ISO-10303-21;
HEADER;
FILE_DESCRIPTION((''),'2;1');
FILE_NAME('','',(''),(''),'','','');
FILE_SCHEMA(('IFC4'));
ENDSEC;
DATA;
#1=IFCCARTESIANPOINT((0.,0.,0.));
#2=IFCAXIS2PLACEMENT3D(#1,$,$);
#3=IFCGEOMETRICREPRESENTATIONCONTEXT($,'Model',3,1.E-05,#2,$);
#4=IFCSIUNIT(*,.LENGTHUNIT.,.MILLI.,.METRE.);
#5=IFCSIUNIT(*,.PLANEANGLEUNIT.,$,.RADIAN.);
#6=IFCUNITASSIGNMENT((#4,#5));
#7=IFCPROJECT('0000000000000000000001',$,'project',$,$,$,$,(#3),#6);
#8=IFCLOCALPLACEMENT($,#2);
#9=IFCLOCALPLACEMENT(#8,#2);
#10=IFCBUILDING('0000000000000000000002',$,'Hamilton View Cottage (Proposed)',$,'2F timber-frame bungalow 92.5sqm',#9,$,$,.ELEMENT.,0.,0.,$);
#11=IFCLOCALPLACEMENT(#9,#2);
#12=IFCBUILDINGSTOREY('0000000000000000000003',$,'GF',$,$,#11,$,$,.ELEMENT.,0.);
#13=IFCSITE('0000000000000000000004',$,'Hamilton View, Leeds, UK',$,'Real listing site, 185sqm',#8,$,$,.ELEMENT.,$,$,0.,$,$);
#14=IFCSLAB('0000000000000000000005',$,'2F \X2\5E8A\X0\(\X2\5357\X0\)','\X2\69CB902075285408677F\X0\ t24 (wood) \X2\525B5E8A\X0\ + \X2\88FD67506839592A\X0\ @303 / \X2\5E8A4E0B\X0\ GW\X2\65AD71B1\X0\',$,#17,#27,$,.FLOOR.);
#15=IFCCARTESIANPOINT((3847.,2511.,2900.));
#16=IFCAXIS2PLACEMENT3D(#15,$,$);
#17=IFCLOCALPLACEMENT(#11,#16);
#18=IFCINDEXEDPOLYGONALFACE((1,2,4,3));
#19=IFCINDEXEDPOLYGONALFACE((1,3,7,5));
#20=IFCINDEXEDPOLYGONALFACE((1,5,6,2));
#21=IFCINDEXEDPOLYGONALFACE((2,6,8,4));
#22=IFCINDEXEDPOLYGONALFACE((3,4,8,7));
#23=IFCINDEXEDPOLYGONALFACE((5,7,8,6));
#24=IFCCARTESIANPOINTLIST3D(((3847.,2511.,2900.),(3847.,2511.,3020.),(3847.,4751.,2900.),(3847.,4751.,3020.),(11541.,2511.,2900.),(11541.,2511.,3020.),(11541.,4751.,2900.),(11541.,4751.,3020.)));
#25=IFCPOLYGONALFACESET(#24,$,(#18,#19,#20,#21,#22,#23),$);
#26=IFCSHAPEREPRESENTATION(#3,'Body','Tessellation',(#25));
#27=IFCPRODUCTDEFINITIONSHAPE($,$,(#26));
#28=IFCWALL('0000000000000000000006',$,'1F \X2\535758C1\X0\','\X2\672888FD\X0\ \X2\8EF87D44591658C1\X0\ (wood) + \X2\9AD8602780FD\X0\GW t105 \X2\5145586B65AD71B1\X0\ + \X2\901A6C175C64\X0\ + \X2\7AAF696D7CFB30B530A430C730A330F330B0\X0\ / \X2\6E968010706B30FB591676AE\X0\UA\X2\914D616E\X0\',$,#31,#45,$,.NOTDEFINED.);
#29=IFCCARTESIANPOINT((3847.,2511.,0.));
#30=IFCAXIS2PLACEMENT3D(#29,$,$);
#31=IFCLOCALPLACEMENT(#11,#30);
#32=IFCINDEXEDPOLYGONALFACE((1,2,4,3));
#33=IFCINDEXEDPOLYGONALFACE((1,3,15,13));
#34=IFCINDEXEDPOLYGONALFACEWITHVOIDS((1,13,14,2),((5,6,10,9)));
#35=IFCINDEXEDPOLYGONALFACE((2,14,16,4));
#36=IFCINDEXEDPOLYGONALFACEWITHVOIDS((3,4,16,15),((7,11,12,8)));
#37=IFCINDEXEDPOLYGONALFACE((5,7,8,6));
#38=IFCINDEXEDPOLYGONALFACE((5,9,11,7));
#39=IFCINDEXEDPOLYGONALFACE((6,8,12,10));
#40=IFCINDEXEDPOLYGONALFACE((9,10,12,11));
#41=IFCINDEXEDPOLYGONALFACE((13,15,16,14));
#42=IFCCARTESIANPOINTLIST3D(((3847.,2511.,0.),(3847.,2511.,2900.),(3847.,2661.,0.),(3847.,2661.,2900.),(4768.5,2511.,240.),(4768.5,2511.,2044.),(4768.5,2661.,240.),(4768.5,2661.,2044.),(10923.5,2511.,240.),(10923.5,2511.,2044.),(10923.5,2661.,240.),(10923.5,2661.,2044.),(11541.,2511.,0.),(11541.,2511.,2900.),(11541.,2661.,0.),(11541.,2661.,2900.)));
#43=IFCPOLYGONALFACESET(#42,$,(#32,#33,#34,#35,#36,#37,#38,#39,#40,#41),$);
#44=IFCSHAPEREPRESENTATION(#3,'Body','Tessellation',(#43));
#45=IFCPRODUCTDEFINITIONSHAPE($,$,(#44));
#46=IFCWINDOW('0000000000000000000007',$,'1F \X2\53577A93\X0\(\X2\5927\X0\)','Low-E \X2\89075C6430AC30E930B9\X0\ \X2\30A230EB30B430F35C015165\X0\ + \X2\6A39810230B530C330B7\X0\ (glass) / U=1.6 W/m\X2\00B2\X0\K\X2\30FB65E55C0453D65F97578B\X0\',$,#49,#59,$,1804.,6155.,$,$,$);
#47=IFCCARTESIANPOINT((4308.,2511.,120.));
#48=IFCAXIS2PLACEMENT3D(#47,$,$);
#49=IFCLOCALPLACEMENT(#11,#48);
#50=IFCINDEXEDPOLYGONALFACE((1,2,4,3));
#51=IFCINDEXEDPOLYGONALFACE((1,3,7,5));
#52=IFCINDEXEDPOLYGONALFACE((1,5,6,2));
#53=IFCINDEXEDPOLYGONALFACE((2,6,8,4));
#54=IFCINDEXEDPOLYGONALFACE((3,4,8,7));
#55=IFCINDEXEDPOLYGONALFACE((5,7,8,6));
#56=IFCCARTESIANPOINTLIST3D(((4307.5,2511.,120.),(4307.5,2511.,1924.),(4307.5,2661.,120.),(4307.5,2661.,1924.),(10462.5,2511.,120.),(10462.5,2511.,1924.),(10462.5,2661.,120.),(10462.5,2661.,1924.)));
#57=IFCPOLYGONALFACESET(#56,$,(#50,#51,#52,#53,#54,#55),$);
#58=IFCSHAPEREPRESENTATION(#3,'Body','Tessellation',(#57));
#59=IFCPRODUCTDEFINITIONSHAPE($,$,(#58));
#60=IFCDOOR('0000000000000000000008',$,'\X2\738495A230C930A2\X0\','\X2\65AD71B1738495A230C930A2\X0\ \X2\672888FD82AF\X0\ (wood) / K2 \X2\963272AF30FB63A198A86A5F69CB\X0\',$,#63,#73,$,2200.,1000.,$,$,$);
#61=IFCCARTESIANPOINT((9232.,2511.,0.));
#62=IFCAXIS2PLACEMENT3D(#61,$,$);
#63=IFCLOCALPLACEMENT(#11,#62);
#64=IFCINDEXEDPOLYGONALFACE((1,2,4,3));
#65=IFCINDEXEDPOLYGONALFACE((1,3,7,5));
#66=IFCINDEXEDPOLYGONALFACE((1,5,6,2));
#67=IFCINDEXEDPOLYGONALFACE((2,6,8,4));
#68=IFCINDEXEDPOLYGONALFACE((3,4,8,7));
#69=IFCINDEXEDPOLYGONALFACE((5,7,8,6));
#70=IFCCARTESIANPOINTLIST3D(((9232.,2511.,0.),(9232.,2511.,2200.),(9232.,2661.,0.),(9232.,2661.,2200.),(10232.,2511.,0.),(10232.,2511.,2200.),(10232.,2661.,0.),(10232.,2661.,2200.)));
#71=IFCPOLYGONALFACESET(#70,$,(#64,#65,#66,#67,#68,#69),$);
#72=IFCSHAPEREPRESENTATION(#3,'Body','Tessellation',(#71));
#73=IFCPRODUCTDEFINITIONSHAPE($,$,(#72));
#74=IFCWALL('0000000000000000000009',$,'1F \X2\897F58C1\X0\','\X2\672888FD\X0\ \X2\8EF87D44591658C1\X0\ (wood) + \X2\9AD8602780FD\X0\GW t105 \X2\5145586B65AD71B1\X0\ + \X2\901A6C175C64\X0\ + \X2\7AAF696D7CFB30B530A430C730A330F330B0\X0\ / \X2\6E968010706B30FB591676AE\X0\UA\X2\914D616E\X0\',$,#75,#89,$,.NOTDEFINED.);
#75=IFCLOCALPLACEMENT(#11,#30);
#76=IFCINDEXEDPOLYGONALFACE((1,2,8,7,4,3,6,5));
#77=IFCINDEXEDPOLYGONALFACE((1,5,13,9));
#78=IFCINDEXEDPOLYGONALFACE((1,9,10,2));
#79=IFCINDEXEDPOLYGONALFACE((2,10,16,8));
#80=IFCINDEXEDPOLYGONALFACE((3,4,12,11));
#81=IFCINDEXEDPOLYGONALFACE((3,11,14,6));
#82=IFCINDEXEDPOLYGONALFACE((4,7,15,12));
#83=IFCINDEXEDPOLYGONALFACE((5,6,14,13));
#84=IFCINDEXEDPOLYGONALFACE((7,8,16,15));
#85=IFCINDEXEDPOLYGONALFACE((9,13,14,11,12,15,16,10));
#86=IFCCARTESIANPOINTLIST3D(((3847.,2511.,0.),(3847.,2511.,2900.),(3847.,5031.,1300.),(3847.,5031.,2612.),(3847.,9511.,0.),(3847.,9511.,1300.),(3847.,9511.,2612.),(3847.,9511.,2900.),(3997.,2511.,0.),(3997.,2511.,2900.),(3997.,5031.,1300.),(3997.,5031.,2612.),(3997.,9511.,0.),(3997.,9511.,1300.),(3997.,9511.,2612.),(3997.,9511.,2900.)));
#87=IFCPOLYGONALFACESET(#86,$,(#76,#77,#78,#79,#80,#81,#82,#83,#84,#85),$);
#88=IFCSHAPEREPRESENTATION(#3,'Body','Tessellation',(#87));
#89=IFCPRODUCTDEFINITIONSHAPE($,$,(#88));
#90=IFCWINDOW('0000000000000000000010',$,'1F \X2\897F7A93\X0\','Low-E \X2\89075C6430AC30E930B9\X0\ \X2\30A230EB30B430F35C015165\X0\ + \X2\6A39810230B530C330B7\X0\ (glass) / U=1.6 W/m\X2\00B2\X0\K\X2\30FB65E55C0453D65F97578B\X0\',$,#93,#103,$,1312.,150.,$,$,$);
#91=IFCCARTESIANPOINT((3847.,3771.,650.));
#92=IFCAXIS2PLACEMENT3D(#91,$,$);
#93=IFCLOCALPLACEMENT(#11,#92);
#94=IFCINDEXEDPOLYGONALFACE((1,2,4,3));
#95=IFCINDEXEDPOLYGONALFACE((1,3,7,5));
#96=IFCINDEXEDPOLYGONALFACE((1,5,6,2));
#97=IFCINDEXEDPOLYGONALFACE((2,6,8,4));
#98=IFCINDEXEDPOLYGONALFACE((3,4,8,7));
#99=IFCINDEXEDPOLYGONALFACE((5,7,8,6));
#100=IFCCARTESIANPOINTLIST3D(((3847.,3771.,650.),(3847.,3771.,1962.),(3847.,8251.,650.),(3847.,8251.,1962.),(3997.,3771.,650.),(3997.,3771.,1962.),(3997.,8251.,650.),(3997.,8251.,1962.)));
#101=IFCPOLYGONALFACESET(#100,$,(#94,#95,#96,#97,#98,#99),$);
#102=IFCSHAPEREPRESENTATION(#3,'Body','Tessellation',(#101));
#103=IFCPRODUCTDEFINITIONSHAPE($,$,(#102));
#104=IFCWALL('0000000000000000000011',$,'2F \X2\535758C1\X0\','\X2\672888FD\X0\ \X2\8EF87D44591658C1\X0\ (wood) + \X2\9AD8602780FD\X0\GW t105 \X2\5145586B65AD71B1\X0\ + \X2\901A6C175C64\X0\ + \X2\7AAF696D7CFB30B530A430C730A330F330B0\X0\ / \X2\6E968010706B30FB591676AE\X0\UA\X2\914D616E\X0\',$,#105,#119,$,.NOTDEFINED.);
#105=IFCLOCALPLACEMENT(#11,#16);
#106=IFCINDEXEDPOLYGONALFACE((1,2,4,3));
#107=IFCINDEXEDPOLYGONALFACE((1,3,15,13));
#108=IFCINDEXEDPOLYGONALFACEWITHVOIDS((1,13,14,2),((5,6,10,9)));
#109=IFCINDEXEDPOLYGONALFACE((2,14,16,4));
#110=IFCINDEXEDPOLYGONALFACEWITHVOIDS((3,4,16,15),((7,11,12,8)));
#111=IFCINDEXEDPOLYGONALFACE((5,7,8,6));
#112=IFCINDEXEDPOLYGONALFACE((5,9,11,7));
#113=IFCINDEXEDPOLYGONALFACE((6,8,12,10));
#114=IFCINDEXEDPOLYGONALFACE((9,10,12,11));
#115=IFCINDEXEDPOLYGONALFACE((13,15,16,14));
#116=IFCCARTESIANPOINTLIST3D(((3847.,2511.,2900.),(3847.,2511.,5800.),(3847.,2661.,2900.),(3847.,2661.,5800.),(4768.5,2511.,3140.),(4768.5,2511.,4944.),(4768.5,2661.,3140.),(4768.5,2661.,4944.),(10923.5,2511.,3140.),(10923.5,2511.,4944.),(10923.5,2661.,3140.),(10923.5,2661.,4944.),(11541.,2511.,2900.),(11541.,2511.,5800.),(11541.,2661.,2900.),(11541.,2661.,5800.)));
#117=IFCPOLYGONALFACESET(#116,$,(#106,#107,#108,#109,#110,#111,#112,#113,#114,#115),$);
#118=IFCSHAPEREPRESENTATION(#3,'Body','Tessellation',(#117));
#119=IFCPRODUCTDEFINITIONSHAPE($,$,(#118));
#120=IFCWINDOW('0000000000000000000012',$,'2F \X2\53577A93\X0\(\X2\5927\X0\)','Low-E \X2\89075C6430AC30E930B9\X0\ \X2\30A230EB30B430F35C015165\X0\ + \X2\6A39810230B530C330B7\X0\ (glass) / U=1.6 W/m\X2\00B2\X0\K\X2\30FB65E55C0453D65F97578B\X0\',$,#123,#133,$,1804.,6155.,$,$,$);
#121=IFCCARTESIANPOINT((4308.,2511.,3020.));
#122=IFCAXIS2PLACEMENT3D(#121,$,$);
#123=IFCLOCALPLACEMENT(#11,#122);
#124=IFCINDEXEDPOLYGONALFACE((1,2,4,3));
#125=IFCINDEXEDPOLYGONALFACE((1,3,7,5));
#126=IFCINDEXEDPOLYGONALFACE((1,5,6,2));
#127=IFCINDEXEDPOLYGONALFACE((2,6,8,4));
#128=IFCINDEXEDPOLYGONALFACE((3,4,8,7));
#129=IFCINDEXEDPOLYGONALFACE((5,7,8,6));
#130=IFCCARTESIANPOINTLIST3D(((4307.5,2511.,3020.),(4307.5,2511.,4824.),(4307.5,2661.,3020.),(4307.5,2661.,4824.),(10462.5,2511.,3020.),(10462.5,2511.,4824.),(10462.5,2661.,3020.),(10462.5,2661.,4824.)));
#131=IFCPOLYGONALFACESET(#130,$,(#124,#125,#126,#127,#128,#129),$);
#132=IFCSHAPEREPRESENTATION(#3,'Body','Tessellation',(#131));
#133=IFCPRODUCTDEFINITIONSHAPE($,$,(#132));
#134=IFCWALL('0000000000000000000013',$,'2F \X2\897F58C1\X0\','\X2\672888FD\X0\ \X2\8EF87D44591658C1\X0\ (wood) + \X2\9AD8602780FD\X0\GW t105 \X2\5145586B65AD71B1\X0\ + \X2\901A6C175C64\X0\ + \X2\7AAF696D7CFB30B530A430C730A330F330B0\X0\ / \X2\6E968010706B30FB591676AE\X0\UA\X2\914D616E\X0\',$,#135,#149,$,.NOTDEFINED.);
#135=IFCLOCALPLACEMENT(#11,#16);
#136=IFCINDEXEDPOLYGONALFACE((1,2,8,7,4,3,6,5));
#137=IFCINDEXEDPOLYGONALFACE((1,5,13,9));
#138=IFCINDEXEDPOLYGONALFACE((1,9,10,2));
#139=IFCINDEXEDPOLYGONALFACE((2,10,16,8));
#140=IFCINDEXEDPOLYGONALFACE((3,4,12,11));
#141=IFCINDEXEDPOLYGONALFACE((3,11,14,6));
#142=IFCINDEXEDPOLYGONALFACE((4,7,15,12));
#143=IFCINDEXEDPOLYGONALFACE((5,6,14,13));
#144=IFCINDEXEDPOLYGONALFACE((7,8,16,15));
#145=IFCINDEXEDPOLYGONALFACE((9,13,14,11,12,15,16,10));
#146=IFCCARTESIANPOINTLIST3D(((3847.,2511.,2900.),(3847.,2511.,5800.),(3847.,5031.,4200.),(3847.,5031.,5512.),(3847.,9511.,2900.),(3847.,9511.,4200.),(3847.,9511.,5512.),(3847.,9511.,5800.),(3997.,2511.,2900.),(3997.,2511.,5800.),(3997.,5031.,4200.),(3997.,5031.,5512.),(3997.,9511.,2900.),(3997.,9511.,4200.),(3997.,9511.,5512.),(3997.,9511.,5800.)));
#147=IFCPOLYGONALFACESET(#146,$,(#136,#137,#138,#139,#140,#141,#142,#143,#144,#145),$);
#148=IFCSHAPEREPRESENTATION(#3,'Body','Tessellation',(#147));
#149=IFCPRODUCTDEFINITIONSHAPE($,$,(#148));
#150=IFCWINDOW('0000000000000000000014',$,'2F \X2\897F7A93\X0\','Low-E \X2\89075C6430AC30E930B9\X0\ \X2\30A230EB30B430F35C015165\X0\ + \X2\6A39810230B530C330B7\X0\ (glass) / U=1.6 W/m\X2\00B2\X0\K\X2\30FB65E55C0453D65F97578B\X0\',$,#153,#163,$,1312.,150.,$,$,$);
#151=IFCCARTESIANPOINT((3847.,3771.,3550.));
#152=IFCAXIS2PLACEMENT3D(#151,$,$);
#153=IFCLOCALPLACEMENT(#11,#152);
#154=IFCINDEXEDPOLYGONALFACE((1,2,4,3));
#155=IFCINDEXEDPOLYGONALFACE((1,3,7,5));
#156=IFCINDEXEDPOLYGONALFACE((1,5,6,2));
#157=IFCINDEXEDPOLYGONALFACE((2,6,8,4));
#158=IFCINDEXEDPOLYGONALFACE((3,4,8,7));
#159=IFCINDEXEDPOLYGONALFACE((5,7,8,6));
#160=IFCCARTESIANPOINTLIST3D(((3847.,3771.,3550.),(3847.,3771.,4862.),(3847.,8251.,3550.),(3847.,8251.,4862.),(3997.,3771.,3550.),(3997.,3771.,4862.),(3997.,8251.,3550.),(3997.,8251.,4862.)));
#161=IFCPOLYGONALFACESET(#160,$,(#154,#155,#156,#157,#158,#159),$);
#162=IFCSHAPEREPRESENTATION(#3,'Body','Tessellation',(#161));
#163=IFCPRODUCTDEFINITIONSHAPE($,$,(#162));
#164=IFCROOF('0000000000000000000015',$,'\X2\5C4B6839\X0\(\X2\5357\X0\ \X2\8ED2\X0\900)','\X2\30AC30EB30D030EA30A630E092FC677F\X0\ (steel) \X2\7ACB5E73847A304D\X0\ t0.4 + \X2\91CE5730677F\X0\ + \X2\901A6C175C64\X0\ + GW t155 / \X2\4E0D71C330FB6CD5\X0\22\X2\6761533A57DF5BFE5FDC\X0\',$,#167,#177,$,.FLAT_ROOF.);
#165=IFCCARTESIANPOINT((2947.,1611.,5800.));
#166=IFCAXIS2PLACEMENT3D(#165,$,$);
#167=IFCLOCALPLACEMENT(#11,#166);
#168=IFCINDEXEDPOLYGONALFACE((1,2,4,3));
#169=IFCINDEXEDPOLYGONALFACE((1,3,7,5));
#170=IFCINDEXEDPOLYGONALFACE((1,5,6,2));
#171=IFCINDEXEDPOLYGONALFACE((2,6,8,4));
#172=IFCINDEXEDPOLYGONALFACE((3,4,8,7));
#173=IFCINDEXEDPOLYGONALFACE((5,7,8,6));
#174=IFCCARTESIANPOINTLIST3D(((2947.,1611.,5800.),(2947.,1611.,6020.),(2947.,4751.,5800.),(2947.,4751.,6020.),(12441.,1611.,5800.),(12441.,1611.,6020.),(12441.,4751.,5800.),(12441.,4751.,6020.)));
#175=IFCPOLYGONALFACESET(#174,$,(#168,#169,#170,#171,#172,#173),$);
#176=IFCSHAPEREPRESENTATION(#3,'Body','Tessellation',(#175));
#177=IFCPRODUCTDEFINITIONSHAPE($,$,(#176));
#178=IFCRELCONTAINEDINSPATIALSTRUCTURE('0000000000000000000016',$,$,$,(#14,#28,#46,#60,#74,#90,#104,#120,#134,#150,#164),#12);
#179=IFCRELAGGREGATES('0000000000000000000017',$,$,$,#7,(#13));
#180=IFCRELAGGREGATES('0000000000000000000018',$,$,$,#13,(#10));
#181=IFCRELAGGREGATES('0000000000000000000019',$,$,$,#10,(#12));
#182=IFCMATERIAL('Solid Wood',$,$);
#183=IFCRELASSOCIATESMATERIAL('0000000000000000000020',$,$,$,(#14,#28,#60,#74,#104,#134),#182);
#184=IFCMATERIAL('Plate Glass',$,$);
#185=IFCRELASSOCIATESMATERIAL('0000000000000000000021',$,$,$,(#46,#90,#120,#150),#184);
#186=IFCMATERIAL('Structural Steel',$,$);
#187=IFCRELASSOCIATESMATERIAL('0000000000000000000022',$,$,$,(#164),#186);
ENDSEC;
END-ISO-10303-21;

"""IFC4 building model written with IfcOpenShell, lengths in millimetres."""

from ifc_helpers import new_model, si_unit, frame, frame_2d, origin, place, context, project, spatial, rectangle, extrude, material, element, fill, save


model = new_model("IFC4")

# Units and contexts
model_context = context("Model", 3, precision=1e-05, world=origin())
ifc_project = project(units=[si_unit("LENGTHUNIT", "METRE", prefix="MILLI"), si_unit("PLANEANGLEUNIT", "RADIAN")], contexts=[model_context])

# Site, building, storey
site_placement = place(None, origin())
site = spatial("IfcSite", under=ifc_project, at=site_placement, Name="Hamilton View, Leeds, UK", ObjectType="Real listing site, 185sqm", CompositionType="ELEMENT", RefElevation=0.0)
building_placement = place(site_placement, origin())
building = spatial("IfcBuilding", under=site, at=building_placement, Name="Hamilton View Cottage (Proposed)", ObjectType="2F timber-frame bungalow 92.5sqm", CompositionType="ELEMENT", ElevationOfRefHeight=0.0, ElevationOfTerrain=0.0)
storey_placement = place(building_placement, origin())
storey = spatial("IfcBuildingStorey", under=building, at=storey_placement, Name="GF", CompositionType="ELEMENT", Elevation=0.0)

# Slab
ifc_material_1 = material(Name="Solid Wood")
slab_1_placement = place(storey_placement, frame((3847.0, 2511.0, 2900.0)))
element("IfcSlab", 1, at=slab_1_placement, inside=storey, material=ifc_material_1, Name="2F 床(南)", Description="構造用合板 t24 (wood) 剛床 + 製材根太 @303 / 床下 GW断熱", PredefinedType="FLOOR", context=model_context, shape_type="SweptSolid", body=[
    extrude(rectangle(XDim=7694.0, YDim=2240.0, at=frame_2d((3847.0, 1120.0))), frame((3847.0, 2511.0, 2900.0)), (0.0, 0.0, 1.0), 120.0),
])

# Wall, openings, window, door
wall_1_placement = place(storey_placement, frame((3847.0, 2511.0, 0.0)))
wall_1 = element("IfcWall", 2, at=wall_1_placement, inside=storey, material=ifc_material_1, Name="1F 南壁", Description="木製 軸組外壁 (wood) + 高性能GW t105 充填断熱 + 通気層 + 窯業系サイディング / 準耐火・外皮UA配慮", PredefinedType="NOTDEFINED", context=model_context, shape_type="SweptSolid", body=[
    extrude(rectangle(XDim=7694.0, YDim=150.0, at=frame_2d((3847.0, 75.0))), frame((3847.0, 2511.0, 0.0)), (0.0, 0.0, 1.0), 2900.0),
])
opening_1_placement = place(storey_placement, frame((4308.0, 2511.0, 120.0)))
opening_1 = element("IfcOpeningElement", 3, at=opening_1_placement, cuts=wall_1, PredefinedType="NOTDEFINED", context=model_context, shape_type="SweptSolid", body=[
    extrude(rectangle(XDim=6155.0, YDim=150.0, at=frame_2d((3077.0, 75.0))), frame((4308.0, 2511.0, 120.0)), (0.0, 0.0, 1.0), 1804.0),
])
opening_2_placement = place(storey_placement, frame((9232.0, 2511.0, 0.0)))
opening_2 = element("IfcOpeningElement", 4, at=opening_2_placement, cuts=wall_1, PredefinedType="NOTDEFINED", context=model_context, shape_type="SweptSolid", body=[
    extrude(rectangle(XDim=1000.0, YDim=150.0, at=frame_2d((500.0, 75.0))), frame((9232.0, 2511.0, 0.0)), (0.0, 0.0, 1.0), 2200.0),
])
ifc_material_2 = material(Name="Plate Glass")
window_1_placement = place(storey_placement, frame((4308.0, 2511.0, 120.0)))
window_1 = element("IfcWindow", 5, at=window_1_placement, inside=storey, material=ifc_material_2, Name="1F 南窓(大)", Description="Low-E 複層ガラス アルゴン封入 + 樹脂サッシ (glass) / U=1.6 W/m²K・日射取得型", OverallHeight=1804.0, OverallWidth=6155.0, context=model_context, shape_type="SweptSolid", body=[
    extrude(rectangle(XDim=6155.0, YDim=150.0, at=frame_2d((3077.0, 75.0))), frame((4308.0, 2511.0, 120.0)), (0.0, 0.0, 1.0), 1804.0),
])
fill(opening_1, window_1)
door_placement = place(storey_placement, frame((9232.0, 2511.0, 0.0)))
door = element("IfcDoor", 6, at=door_placement, inside=storey, material=ifc_material_1, Name="玄関ドア", Description="断熱玄関ドア 木製芯 (wood) / K2 防犯・採風機構", OverallHeight=2200.0, OverallWidth=1000.0, context=model_context, shape_type="SweptSolid", body=[
    extrude(rectangle(XDim=1000.0, YDim=150.0, at=frame_2d((500.0, 75.0))), frame((9232.0, 2511.0, 0.0)), (0.0, 0.0, 1.0), 2200.0),
])
fill(opening_2, door)

# Walls, openings, windows
wall_2_placement = place(storey_placement, frame((3847.0, 2511.0, 0.0)))
wall_2 = element("IfcWall", 7, at=wall_2_placement, inside=storey, material=ifc_material_1, Name="1F 西壁", Description="木製 軸組外壁 (wood) + 高性能GW t105 充填断熱 + 通気層 + 窯業系サイディング / 準耐火・外皮UA配慮", PredefinedType="NOTDEFINED", context=model_context, shape_type="SweptSolid", body=[
    extrude(rectangle(XDim=150.0, YDim=7000.0, at=frame_2d((75.0, 3500.0))), frame((3847.0, 2511.0, 0.0)), (0.0, 0.0, 1.0), 2900.0),
])
opening_3_placement = place(storey_placement, frame((3847.0, 3771.0, 650.0)))
opening_3 = element("IfcOpeningElement", 8, at=opening_3_placement, cuts=wall_2, PredefinedType="NOTDEFINED", context=model_context, shape_type="SweptSolid", body=[
    extrude(rectangle(XDim=150.0, YDim=4480.0, at=frame_2d((75.0, 2240.0))), frame((3847.0, 3771.0, 650.0)), (0.0, 0.0, 1.0), 1312.0),
])
window_2_placement = place(storey_placement, frame((3847.0, 3771.0, 650.0)))
window_2 = element("IfcWindow", 9, at=window_2_placement, inside=storey, material=ifc_material_2, Name="1F 西窓", Description="Low-E 複層ガラス アルゴン封入 + 樹脂サッシ (glass) / U=1.6 W/m²K・日射取得型", OverallHeight=1312.0, OverallWidth=150.0, context=model_context, shape_type="SweptSolid", body=[
    extrude(rectangle(XDim=150.0, YDim=4480.0, at=frame_2d((75.0, 2240.0))), frame((3847.0, 3771.0, 650.0)), (0.0, 0.0, 1.0), 1312.0),
])
fill(opening_3, window_2)
wall_3_placement = place(storey_placement, frame((3847.0, 2511.0, 2900.0)))
wall_3 = element("IfcWall", 10, at=wall_3_placement, inside=storey, material=ifc_material_1, Name="2F 南壁", Description="木製 軸組外壁 (wood) + 高性能GW t105 充填断熱 + 通気層 + 窯業系サイディング / 準耐火・外皮UA配慮", PredefinedType="NOTDEFINED", context=model_context, shape_type="SweptSolid", body=[
    extrude(rectangle(XDim=7694.0, YDim=150.0, at=frame_2d((3847.0, 75.0))), frame((3847.0, 2511.0, 2900.0)), (0.0, 0.0, 1.0), 2900.0),
])
opening_4_placement = place(storey_placement, frame((4308.0, 2511.0, 3020.0)))
opening_4 = element("IfcOpeningElement", 11, at=opening_4_placement, cuts=wall_3, PredefinedType="NOTDEFINED", context=model_context, shape_type="SweptSolid", body=[
    extrude(rectangle(XDim=6155.0, YDim=150.0, at=frame_2d((3077.0, 75.0))), frame((4308.0, 2511.0, 3020.0)), (0.0, 0.0, 1.0), 1804.0),
])
window_3_placement = place(storey_placement, frame((4308.0, 2511.0, 3020.0)))
window_3 = element("IfcWindow", 12, at=window_3_placement, inside=storey, material=ifc_material_2, Name="2F 南窓(大)", Description="Low-E 複層ガラス アルゴン封入 + 樹脂サッシ (glass) / U=1.6 W/m²K・日射取得型", OverallHeight=1804.0, OverallWidth=6155.0, context=model_context, shape_type="SweptSolid", body=[
    extrude(rectangle(XDim=6155.0, YDim=150.0, at=frame_2d((3077.0, 75.0))), frame((4308.0, 2511.0, 3020.0)), (0.0, 0.0, 1.0), 1804.0),
])
fill(opening_4, window_3)
wall_4_placement = place(storey_placement, frame((3847.0, 2511.0, 2900.0)))
wall_4 = element("IfcWall", 13, at=wall_4_placement, inside=storey, material=ifc_material_1, Name="2F 西壁", Description="木製 軸組外壁 (wood) + 高性能GW t105 充填断熱 + 通気層 + 窯業系サイディング / 準耐火・外皮UA配慮", PredefinedType="NOTDEFINED", context=model_context, shape_type="SweptSolid", body=[
    extrude(rectangle(XDim=150.0, YDim=7000.0, at=frame_2d((75.0, 3500.0))), frame((3847.0, 2511.0, 2900.0)), (0.0, 0.0, 1.0), 2900.0),
])
opening_5_placement = place(storey_placement, frame((3847.0, 3771.0, 3550.0)))
opening_5 = element("IfcOpeningElement", 14, at=opening_5_placement, cuts=wall_4, PredefinedType="NOTDEFINED", context=model_context, shape_type="SweptSolid", body=[
    extrude(rectangle(XDim=150.0, YDim=4480.0, at=frame_2d((75.0, 2240.0))), frame((3847.0, 3771.0, 3550.0)), (0.0, 0.0, 1.0), 1312.0),
])
window_4_placement = place(storey_placement, frame((3847.0, 3771.0, 3550.0)))
window_4 = element("IfcWindow", 15, at=window_4_placement, inside=storey, material=ifc_material_2, Name="2F 西窓", Description="Low-E 複層ガラス アルゴン封入 + 樹脂サッシ (glass) / U=1.6 W/m²K・日射取得型", OverallHeight=1312.0, OverallWidth=150.0, context=model_context, shape_type="SweptSolid", body=[
    extrude(rectangle(XDim=150.0, YDim=4480.0, at=frame_2d((75.0, 2240.0))), frame((3847.0, 3771.0, 3550.0)), (0.0, 0.0, 1.0), 1312.0),
])
fill(opening_5, window_4)

# Roof
ifc_material_3 = material(Name="Structural Steel")
roof_1_placement = place(storey_placement, frame((2947.0, 1611.0, 5800.0)))
element("IfcRoof", 16, at=roof_1_placement, inside=storey, material=ifc_material_3, Name="屋根(南 軒900)", Description="ガルバリウム鋼板 (steel) 立平葺き t0.4 + 野地板 + 通気層 + GW t155 / 不燃・法22条区域対応", PredefinedType="FLAT_ROOF", context=model_context, shape_type="SweptSolid", body=[
    extrude(rectangle(XDim=9494.0, YDim=3140.0, at=frame_2d((4747.0, 1570.0))), frame((2947.0, 1611.0, 5800.0)), (0.0, 0.0, 1.0), 220.0),
])

save(model, "model.ifc")
